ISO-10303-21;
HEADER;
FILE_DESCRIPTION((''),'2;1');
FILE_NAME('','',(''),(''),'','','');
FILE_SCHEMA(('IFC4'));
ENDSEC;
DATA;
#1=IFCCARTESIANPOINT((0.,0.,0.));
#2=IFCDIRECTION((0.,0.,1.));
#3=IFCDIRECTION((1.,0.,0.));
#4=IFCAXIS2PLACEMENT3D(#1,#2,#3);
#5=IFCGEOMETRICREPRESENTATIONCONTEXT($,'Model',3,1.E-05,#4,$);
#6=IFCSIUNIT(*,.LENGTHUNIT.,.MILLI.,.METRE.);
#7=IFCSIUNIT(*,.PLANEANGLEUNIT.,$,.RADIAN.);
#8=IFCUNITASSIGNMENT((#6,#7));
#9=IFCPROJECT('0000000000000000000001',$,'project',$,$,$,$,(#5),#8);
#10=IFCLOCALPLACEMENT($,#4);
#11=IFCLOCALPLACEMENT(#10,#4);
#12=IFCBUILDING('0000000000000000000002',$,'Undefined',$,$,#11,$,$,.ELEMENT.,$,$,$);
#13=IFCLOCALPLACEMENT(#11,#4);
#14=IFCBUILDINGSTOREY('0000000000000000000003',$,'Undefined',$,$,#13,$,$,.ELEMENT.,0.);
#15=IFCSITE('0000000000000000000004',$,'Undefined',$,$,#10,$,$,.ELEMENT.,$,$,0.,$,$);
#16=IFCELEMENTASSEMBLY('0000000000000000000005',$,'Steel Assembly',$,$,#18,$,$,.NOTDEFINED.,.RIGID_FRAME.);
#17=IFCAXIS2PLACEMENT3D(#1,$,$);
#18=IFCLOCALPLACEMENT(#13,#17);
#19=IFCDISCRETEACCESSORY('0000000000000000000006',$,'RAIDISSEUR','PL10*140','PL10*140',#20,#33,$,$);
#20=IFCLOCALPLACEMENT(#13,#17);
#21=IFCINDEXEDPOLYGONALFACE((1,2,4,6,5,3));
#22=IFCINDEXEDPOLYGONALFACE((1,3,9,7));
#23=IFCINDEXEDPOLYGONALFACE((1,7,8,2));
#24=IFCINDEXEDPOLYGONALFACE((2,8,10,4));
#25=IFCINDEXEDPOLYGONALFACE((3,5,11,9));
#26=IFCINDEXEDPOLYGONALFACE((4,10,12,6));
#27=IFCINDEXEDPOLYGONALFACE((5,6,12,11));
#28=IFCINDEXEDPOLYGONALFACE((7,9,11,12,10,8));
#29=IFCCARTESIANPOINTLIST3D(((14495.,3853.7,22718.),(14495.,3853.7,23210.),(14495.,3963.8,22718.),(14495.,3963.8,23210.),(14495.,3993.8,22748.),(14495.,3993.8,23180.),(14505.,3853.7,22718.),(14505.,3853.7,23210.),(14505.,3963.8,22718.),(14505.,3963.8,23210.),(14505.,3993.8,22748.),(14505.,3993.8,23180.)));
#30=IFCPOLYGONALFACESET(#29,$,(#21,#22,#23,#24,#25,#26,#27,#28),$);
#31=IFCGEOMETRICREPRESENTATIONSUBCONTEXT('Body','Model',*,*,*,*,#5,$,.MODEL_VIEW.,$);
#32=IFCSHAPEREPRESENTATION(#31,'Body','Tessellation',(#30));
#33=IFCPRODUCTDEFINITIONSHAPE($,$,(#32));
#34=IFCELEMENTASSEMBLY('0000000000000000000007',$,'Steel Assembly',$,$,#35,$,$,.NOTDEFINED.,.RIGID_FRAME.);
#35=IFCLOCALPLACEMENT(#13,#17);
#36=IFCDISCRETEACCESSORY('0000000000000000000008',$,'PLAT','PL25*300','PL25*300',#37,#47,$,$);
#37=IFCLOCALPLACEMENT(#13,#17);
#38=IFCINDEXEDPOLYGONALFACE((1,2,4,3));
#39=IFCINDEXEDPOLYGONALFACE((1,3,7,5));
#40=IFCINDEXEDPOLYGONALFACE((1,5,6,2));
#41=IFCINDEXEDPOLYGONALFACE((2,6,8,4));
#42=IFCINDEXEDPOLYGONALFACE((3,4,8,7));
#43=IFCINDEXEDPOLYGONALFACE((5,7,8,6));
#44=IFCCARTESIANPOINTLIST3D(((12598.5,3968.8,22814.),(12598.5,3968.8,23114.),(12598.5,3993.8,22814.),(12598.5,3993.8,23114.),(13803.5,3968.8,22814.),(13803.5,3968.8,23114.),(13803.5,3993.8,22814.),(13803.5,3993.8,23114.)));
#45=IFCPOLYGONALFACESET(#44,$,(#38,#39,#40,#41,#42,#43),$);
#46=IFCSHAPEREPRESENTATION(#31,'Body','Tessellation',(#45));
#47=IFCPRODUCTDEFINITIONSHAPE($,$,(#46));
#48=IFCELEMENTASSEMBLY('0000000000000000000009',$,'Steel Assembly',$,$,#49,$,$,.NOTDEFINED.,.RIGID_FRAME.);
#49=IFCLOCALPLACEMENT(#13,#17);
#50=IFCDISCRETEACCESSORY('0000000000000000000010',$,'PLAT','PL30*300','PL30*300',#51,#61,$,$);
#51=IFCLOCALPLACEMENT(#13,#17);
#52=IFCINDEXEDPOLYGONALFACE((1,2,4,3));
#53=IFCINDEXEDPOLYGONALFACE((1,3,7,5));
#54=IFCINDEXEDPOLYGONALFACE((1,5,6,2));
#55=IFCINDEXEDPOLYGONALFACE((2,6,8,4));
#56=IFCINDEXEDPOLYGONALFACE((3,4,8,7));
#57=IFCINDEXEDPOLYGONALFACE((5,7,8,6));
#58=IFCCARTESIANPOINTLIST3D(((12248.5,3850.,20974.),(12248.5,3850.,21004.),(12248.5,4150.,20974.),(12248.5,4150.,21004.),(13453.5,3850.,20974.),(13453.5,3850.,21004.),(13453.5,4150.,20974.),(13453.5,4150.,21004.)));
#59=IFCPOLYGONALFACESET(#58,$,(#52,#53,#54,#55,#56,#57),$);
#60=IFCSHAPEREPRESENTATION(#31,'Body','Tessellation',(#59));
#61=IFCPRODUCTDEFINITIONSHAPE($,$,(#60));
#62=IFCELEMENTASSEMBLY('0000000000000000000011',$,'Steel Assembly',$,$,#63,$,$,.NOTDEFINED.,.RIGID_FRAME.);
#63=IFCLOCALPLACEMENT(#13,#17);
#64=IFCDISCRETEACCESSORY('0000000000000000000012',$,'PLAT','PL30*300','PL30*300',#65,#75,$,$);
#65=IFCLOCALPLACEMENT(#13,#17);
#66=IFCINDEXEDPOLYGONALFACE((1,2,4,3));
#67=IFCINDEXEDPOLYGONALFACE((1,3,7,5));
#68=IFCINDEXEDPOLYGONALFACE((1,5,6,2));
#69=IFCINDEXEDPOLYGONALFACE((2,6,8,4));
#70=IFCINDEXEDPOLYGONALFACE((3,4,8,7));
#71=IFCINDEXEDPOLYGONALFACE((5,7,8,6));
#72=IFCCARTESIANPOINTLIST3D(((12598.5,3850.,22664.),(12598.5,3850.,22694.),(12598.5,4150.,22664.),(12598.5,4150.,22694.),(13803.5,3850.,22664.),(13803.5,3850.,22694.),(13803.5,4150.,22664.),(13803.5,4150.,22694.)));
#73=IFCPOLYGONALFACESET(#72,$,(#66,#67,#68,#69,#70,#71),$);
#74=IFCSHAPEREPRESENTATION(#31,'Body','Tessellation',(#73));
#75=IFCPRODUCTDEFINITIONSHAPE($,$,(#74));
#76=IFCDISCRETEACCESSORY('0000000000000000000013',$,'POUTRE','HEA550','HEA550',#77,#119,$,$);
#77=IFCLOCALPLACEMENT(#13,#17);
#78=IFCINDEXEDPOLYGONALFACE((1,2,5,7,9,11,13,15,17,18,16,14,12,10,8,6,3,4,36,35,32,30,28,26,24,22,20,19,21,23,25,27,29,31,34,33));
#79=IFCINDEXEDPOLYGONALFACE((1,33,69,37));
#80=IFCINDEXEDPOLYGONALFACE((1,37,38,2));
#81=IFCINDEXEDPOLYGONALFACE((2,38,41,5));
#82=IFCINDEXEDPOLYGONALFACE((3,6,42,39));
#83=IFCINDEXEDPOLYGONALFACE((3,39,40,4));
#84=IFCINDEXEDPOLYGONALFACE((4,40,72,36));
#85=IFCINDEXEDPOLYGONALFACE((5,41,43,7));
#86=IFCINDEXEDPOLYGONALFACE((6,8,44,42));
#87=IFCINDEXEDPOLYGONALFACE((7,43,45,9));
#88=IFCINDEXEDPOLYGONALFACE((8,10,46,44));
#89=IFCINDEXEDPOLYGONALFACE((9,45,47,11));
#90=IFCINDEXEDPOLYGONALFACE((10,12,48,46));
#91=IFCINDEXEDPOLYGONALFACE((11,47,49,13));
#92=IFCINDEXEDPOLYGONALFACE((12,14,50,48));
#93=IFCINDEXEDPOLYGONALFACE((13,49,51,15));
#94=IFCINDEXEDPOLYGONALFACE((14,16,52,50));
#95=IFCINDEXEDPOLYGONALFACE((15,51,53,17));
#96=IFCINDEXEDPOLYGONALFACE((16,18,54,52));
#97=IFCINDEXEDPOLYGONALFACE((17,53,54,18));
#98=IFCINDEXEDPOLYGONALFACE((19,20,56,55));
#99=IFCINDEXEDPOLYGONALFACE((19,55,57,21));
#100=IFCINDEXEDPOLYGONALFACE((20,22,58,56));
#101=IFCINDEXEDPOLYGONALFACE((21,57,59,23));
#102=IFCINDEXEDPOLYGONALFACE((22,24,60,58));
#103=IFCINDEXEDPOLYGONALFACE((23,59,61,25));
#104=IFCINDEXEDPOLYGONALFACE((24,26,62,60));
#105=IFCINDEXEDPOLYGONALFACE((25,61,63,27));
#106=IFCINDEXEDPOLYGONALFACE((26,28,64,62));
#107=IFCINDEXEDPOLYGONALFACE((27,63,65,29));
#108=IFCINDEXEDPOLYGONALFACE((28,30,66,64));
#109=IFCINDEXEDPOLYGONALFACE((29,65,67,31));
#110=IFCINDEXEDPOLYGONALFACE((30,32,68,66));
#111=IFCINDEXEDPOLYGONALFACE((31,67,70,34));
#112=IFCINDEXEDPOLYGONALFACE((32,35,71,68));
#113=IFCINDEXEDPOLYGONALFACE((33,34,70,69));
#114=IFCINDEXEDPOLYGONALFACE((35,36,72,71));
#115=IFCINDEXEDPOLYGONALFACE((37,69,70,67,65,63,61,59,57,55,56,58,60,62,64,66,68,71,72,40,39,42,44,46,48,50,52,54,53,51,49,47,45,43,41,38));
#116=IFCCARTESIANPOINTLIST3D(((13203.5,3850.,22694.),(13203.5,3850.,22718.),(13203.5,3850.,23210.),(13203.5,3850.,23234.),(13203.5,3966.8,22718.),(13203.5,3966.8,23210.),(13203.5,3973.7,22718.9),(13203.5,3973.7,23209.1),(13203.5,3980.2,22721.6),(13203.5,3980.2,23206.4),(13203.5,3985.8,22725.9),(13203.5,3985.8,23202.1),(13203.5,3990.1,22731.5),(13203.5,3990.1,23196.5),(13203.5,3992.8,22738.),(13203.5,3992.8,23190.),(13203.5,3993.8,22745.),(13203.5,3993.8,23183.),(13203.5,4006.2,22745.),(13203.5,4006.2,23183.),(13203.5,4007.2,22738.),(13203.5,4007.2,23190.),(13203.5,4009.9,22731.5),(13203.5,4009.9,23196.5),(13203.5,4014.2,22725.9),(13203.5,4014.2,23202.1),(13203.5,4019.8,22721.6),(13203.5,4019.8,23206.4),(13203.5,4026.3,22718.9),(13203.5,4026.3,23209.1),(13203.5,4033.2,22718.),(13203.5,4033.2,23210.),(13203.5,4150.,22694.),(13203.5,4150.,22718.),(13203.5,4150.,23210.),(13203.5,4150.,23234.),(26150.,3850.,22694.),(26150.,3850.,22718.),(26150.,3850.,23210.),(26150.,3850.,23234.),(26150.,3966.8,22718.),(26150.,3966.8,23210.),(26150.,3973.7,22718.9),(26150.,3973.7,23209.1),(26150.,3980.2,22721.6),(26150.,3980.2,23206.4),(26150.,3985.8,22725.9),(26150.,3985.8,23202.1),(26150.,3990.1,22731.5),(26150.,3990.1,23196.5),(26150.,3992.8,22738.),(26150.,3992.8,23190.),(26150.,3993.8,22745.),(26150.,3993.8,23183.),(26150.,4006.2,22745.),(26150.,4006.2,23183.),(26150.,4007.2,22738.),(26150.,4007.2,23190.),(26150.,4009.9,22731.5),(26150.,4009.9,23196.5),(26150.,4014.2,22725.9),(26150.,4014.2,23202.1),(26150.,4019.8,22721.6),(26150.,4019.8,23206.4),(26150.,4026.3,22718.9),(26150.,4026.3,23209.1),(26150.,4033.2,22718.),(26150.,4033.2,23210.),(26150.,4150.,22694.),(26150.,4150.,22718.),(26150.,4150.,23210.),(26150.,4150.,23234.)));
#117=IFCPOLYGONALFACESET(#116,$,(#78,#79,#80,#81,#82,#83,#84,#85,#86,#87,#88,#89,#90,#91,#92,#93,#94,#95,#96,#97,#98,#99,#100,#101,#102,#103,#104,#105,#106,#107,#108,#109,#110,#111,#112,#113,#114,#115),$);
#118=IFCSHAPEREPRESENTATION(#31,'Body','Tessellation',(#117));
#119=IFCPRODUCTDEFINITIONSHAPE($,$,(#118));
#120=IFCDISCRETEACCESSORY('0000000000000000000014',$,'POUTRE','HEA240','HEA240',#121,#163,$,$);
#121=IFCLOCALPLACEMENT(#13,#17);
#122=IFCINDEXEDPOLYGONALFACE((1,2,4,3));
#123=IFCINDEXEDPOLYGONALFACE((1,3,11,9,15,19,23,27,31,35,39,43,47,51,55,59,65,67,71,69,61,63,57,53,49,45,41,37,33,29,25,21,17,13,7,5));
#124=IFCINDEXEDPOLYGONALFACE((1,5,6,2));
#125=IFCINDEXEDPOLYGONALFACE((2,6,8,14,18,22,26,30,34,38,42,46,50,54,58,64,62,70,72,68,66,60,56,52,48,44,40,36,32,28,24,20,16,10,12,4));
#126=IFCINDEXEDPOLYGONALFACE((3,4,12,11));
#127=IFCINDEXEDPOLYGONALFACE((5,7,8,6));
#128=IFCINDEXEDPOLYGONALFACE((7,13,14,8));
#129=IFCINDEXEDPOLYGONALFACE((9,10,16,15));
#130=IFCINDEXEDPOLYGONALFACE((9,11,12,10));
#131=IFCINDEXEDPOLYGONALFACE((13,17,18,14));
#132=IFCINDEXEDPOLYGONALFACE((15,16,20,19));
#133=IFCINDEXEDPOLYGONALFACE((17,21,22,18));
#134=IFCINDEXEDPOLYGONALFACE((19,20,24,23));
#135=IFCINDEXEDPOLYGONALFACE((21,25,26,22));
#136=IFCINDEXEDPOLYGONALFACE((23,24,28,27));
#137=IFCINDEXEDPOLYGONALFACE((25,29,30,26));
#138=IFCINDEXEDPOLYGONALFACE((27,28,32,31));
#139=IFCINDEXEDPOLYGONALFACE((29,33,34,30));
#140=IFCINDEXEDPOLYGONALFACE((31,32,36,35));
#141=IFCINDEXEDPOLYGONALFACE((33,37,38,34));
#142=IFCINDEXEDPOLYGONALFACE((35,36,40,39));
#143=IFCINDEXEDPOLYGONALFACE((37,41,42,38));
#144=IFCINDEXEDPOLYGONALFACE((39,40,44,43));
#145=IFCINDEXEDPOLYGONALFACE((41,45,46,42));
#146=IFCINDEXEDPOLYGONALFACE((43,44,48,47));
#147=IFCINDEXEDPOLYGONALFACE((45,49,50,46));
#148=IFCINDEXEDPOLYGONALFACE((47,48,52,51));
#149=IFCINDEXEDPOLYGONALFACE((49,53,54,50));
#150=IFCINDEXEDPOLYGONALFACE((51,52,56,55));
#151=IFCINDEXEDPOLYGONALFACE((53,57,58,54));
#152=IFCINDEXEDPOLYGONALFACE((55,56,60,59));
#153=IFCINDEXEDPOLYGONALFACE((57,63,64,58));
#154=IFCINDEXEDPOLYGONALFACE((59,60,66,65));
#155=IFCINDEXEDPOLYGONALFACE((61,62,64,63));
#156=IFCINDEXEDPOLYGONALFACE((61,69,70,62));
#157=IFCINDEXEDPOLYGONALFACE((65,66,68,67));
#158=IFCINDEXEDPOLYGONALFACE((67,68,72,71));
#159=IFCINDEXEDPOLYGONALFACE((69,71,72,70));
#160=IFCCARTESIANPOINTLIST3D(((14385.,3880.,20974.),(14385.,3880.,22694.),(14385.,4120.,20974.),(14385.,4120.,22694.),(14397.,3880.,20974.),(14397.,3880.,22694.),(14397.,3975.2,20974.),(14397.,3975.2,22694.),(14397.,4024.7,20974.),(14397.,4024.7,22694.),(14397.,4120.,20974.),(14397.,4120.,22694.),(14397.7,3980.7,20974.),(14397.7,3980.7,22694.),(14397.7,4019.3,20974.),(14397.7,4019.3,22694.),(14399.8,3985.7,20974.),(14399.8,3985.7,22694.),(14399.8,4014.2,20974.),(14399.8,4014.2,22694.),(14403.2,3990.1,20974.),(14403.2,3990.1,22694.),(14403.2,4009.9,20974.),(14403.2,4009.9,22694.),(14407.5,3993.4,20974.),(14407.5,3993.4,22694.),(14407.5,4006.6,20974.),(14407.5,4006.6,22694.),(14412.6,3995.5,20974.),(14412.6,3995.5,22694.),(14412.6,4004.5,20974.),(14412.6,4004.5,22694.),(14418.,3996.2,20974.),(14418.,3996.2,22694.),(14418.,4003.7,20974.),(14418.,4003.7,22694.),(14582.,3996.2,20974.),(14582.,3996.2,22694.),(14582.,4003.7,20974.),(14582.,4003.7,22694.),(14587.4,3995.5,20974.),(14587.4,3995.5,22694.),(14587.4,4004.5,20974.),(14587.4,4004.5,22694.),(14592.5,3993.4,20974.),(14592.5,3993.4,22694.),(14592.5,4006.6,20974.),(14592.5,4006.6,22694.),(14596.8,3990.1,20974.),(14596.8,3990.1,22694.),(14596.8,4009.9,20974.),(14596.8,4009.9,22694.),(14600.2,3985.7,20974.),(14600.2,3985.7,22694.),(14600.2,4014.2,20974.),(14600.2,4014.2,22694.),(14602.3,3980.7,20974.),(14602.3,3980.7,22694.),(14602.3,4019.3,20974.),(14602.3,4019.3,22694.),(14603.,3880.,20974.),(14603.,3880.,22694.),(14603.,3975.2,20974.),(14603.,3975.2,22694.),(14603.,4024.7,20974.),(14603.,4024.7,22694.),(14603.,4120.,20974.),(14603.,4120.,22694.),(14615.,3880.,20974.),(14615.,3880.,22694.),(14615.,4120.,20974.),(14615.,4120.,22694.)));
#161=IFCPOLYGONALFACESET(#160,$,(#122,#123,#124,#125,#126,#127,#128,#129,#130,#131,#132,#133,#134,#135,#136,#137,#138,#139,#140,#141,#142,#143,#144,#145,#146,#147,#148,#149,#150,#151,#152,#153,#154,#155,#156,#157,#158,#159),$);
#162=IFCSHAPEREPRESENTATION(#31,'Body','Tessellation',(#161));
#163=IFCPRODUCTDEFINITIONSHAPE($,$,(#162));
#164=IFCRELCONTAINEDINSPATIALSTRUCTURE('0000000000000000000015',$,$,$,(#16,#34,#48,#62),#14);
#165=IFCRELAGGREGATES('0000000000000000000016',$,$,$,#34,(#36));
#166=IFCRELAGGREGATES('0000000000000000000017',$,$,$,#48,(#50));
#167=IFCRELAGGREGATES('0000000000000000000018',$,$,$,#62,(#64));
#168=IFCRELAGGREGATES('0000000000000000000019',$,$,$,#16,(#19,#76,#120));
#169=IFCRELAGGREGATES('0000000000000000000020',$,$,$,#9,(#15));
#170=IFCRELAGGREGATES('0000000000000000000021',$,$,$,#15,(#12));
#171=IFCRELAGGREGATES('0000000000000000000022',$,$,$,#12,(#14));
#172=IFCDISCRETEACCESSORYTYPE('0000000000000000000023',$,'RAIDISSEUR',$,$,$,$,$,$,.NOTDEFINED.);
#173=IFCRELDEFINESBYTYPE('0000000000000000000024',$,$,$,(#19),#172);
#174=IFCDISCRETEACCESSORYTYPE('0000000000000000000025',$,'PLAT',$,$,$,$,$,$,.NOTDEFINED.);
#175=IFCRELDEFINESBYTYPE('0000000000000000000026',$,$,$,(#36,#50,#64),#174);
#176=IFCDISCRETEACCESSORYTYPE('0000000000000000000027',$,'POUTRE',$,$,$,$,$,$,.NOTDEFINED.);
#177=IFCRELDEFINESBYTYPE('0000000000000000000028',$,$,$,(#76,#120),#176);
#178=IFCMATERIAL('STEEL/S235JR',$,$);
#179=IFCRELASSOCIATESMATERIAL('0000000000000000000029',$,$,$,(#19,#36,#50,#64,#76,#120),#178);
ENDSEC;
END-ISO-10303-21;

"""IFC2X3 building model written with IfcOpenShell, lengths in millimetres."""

from ifc_helpers import new_model, si_unit, frame, origin_with_axes, origin_2d_with_axis, place, context, subcontext, project, spatial, polyline, i_section, outline, extrude, material, type_object, element, aggregate, save


model = new_model("IFC2X3")

# Units and contexts
model_context = context("Model", 3, precision=1e-05, world=origin_with_axes())
body_context = subcontext(model_context, "Body", "Model", "MODEL_VIEW")
ifc_project = project(units=[si_unit("LENGTHUNIT", "METRE", prefix="MILLI"), si_unit("PLANEANGLEUNIT", "RADIAN")], contexts=[model_context])

# Site, building, storey
site_placement = place(None, origin_with_axes())
site = spatial("IfcSite", under=ifc_project, at=site_placement, Name="Undefined", CompositionType="ELEMENT", RefElevation=0.0)
building_placement = place(site_placement, origin_with_axes())
building = spatial("IfcBuilding", under=site, at=building_placement, Name="Undefined", CompositionType="ELEMENT")
storey_placement = place(building_placement, origin_with_axes())
storey = spatial("IfcBuildingStorey", under=building, at=storey_placement, Name="Undefined", CompositionType="ELEMENT", Elevation=0.0)

# Shared definitions
ifc_material_1 = material(Name="STEEL/S235JR")

# Element assembly
assembly_1_placement = place(storey_placement, origin_with_axes())
assembly_1 = element("IfcElementAssembly", 1, at=assembly_1_placement, inside=storey, Name="Steel Assembly", AssemblyPlace="NOTDEFINED", PredefinedType="RIGID_FRAME")

# Discrete accessory
discrete_accessory_type_1 = type_object("IfcDiscreteAccessoryType", Name="RAIDISSEUR")
discrete_accessory_1_placement = place(assembly_1_placement, frame((14500.0, 3993.8, 22718.0), z_axis=(-1.0, 0.0, 0.0), x_axis=(0.0, -1.0, 0.0)))
discrete_accessory_1 = element("IfcDiscreteAccessory", 2, at=discrete_accessory_1_placement, type_object=discrete_accessory_type_1, material=ifc_material_1, Name="RAIDISSEUR", Description="PL10*140", ObjectType="PL10*140", context=body_context, shape_type="SweptSolid", body=[
    extrude(outline(polyline([(0.0, 30.0), (30.0, 0.0), (140.0, 0.0), (140.0, 492.0), (30.0, 492.0), (0.0, 462.0), (0.0, 30.0)])), frame((0.0, 0.0, -5.0), z_axis=(0.0, 0.0, 1.0), x_axis=(1.0, 0.0, 0.0)), (0.0, 0.0, 1.0), 10.0),
])

# Element assemblies, discrete accessories
assembly_2_placement = place(storey_placement, origin_with_axes())
assembly_2 = element("IfcElementAssembly", 3, at=assembly_2_placement, inside=storey, Name="Steel Assembly", AssemblyPlace="NOTDEFINED", PredefinedType="RIGID_FRAME")
discrete_accessory_type_2 = type_object("IfcDiscreteAccessoryType", Name="PLAT")
discrete_accessory_2_placement = place(assembly_2_placement, frame((13803.5, 3981.2, 22964.0), z_axis=(0.0, 1.0, 0.0), x_axis=(-1.0, 0.0, 0.0)))
discrete_accessory_2 = element("IfcDiscreteAccessory", 4, at=discrete_accessory_2_placement, type_object=discrete_accessory_type_2, material=ifc_material_1, Name="PLAT", Description="PL25*300", ObjectType="PL25*300", context=body_context, shape_type="SweptSolid", body=[
    extrude(outline(polyline([(0.0, -150.0), (0.0, 150.0), (1205.0, 150.0), (1205.0, -150.0), (0.0, -150.0)])), frame((0.0, 0.0, -12.5), z_axis=(0.0, 0.0, 1.0), x_axis=(1.0, 0.0, 0.0)), (0.0, 0.0, 1.0), 25.0),
])
aggregate(assembly_2, [discrete_accessory_2])
assembly_3_placement = place(storey_placement, origin_with_axes())
assembly_3 = element("IfcElementAssembly", 5, at=assembly_3_placement, inside=storey, Name="Steel Assembly", AssemblyPlace="NOTDEFINED", PredefinedType="RIGID_FRAME")
discrete_accessory_3_placement = place(assembly_3_placement, frame((13453.5, 4000.0, 20989.0), z_axis=(0.0, 0.0, -1.0), x_axis=(-1.0, 0.0, 0.0)))
discrete_accessory_3 = element("IfcDiscreteAccessory", 6, at=discrete_accessory_3_placement, type_object=discrete_accessory_type_2, material=ifc_material_1, Name="PLAT", Description="PL30*300", ObjectType="PL30*300", context=body_context, shape_type="SweptSolid", body=[
    extrude(outline(polyline([(0.0, -150.0), (0.0, 150.0), (1205.0, 150.0), (1205.0, -150.0), (0.0, -150.0)])), frame((0.0, 0.0, -15.0), z_axis=(0.0, 0.0, 1.0), x_axis=(1.0, 0.0, 0.0)), (0.0, 0.0, 1.0), 30.0),
])
aggregate(assembly_3, [discrete_accessory_3])
assembly_4_placement = place(storey_placement, origin_with_axes())
assembly_4 = element("IfcElementAssembly", 7, at=assembly_4_placement, inside=storey, Name="Steel Assembly", AssemblyPlace="NOTDEFINED", PredefinedType="RIGID_FRAME")
discrete_accessory_4_placement = place(assembly_4_placement, frame((13803.5, 4000.0, 22679.0), z_axis=(0.0, 0.0, -1.0), x_axis=(-1.0, 0.0, 0.0)))
discrete_accessory_4 = element("IfcDiscreteAccessory", 8, at=discrete_accessory_4_placement, type_object=discrete_accessory_type_2, material=ifc_material_1, Name="PLAT", Description="PL30*300", ObjectType="PL30*300", context=body_context, shape_type="SweptSolid", body=[
    extrude(outline(polyline([(0.0, -150.0), (0.0, 150.0), (1205.0, 150.0), (1205.0, -150.0), (0.0, -150.0)])), frame((0.0, 0.0, -15.0), z_axis=(0.0, 0.0, 1.0), x_axis=(1.0, 0.0, 0.0)), (0.0, 0.0, 1.0), 30.0),
])
aggregate(assembly_4, [discrete_accessory_4])

# Discrete accessories
discrete_accessory_type_3 = type_object("IfcDiscreteAccessoryType", Name="POUTRE")
discrete_accessory_5_placement = place(assembly_1_placement, frame((13201.0, 4000.0, 22964.0), z_axis=(0.0, 0.0, 1.0), x_axis=(1.0, 0.0, 0.0)))
discrete_accessory_5 = element("IfcDiscreteAccessory", 9, at=discrete_accessory_5_placement, type_object=discrete_accessory_type_3, material=ifc_material_1, Name="POUTRE", Description="HEA550", ObjectType="HEA550", context=body_context, shape_type="SweptSolid", body=[
    extrude(i_section(OverallWidth=300.0, OverallDepth=540.0, WebThickness=12.5, FlangeThickness=24.0, FilletRadius=27.0, at=origin_2d_with_axis()), frame((12949.0, 0.0, 0.0), z_axis=(-1.0, 0.0, 0.0), x_axis=(0.0, -1.0, 0.0)), (0.0, 0.0, 1.0), 12946.5),
])
discrete_accessory_6_placement = place(assembly_1_placement, frame((14500.0, 4000.0, 20974.0), z_axis=(0.0, 0.0, 1.0), x_axis=(1.0, 0.0, 0.0)))
discrete_accessory_6 = element("IfcDiscreteAccessory", 10, at=discrete_accessory_6_placement, type_object=discrete_accessory_type_3, material=ifc_material_1, Name="POUTRE", Description="HEA240", ObjectType="HEA240", context=body_context, shape_type="SweptSolid", body=[
    extrude(i_section(OverallWidth=240.0, OverallDepth=230.0, WebThickness=7.5, FlangeThickness=12.0, FilletRadius=21.0, at=origin_2d_with_axis()), frame((0.0, 0.0, 1720.0), z_axis=(0.0, 0.0, -1.0), x_axis=(0.0, -1.0, 0.0)), (0.0, 0.0, 1.0), 1720.0),
])
aggregate(assembly_1, [discrete_accessory_1, discrete_accessory_5, discrete_accessory_6])

save(model, "model.ifc")
